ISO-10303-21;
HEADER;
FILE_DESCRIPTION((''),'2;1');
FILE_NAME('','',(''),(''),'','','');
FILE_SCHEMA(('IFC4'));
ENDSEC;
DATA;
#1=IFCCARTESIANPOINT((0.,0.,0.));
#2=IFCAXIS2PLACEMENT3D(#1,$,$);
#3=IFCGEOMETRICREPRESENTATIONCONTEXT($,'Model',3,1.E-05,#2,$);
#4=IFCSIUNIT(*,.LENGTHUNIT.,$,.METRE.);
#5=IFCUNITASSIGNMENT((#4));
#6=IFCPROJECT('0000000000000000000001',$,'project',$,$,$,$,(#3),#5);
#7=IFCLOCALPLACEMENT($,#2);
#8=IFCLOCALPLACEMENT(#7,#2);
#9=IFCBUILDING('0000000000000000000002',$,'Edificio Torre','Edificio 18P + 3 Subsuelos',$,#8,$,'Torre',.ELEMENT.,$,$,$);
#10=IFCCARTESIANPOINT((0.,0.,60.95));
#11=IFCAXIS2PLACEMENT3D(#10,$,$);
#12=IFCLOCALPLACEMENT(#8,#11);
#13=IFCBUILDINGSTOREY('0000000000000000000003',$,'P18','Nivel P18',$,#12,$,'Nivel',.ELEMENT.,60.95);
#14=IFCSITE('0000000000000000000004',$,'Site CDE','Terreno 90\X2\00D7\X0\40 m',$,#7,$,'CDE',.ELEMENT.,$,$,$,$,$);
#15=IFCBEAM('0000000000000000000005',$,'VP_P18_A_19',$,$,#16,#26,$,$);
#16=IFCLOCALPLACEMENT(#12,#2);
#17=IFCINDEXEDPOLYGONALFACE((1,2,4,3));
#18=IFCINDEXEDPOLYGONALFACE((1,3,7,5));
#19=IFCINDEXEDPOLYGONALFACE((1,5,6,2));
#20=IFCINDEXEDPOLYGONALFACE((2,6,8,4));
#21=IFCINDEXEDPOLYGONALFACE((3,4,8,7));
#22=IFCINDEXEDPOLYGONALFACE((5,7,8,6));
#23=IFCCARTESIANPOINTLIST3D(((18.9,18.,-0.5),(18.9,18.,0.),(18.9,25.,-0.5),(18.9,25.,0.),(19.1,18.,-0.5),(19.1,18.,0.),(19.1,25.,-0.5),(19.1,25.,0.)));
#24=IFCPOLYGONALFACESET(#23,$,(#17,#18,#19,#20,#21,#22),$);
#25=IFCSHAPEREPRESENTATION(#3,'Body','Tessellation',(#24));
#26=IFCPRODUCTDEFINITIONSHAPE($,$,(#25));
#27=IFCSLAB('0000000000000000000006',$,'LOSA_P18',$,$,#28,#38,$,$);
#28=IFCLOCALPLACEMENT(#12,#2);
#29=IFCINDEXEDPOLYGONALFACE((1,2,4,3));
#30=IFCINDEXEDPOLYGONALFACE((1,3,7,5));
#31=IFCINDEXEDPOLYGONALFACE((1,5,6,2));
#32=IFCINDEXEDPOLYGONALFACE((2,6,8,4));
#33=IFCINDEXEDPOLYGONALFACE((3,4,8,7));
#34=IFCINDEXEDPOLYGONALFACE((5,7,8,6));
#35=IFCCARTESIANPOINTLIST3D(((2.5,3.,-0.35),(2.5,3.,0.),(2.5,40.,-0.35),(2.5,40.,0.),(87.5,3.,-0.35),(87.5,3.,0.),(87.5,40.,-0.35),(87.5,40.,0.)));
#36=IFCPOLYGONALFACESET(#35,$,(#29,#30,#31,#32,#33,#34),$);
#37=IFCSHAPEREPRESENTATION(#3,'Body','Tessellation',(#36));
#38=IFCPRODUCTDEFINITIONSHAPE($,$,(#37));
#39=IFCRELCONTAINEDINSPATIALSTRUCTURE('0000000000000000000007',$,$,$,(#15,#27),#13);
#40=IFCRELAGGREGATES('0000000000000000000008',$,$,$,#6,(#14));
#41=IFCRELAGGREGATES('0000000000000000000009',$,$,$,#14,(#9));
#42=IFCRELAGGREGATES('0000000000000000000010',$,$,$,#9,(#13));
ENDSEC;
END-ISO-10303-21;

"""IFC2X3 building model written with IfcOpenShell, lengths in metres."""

from ifc_helpers import new_model, si_unit, frame, origin, origin_2d, place, context, project, spatial, rectangle, extrude, element, save


model = new_model("IFC2X3")

# Units and contexts
model_context = context("Model", 3, precision=1e-05, world=origin())
ifc_project = project(units=[si_unit("LENGTHUNIT", "METRE")], contexts=[model_context])

# Site, building, storey
site_placement = place(None, origin())
site = spatial("IfcSite", under=ifc_project, at=site_placement, Name="Site CDE", Description="Terreno 90×40 m", LongName="CDE", CompositionType="ELEMENT")
building_placement = place(site_placement, origin())
building = spatial("IfcBuilding", under=site, at=building_placement, Name="Edificio Torre", Description="Edificio 18P + 3 Subsuelos", LongName="Torre", CompositionType="ELEMENT")
storey_placement = place(building_placement, frame((0.0, 0.0, 60.95)))
storey = spatial("IfcBuildingStorey", under=building, at=storey_placement, Name="P18", Description="Nivel P18", LongName="Nivel", CompositionType="ELEMENT", Elevation=60.95)

# Beam
beam_1_placement = place(storey_placement, frame((19.0, 21.5, -0.5)))
element("IfcBeam", 1, at=beam_1_placement, inside=storey, Name="VP_P18_A_19", context=model_context, shape_type="SweptSolid", body=[
    extrude(rectangle(XDim=0.2, YDim=7.0, at=origin_2d()), origin(), (0.0, 0.0, 1.0), 0.5),
])

# Slab
slab_placement = place(storey_placement, frame((45.0, 21.5, -0.35)))
element("IfcSlab", 2, at=slab_placement, inside=storey, Name="LOSA_P18", context=model_context, shape_type="SweptSolid", body=[
    extrude(rectangle(XDim=85.0, YDim=37.0, at=origin_2d()), origin(), (0.0, 0.0, 1.0), 0.35),
])

save(model, "model.ifc")
